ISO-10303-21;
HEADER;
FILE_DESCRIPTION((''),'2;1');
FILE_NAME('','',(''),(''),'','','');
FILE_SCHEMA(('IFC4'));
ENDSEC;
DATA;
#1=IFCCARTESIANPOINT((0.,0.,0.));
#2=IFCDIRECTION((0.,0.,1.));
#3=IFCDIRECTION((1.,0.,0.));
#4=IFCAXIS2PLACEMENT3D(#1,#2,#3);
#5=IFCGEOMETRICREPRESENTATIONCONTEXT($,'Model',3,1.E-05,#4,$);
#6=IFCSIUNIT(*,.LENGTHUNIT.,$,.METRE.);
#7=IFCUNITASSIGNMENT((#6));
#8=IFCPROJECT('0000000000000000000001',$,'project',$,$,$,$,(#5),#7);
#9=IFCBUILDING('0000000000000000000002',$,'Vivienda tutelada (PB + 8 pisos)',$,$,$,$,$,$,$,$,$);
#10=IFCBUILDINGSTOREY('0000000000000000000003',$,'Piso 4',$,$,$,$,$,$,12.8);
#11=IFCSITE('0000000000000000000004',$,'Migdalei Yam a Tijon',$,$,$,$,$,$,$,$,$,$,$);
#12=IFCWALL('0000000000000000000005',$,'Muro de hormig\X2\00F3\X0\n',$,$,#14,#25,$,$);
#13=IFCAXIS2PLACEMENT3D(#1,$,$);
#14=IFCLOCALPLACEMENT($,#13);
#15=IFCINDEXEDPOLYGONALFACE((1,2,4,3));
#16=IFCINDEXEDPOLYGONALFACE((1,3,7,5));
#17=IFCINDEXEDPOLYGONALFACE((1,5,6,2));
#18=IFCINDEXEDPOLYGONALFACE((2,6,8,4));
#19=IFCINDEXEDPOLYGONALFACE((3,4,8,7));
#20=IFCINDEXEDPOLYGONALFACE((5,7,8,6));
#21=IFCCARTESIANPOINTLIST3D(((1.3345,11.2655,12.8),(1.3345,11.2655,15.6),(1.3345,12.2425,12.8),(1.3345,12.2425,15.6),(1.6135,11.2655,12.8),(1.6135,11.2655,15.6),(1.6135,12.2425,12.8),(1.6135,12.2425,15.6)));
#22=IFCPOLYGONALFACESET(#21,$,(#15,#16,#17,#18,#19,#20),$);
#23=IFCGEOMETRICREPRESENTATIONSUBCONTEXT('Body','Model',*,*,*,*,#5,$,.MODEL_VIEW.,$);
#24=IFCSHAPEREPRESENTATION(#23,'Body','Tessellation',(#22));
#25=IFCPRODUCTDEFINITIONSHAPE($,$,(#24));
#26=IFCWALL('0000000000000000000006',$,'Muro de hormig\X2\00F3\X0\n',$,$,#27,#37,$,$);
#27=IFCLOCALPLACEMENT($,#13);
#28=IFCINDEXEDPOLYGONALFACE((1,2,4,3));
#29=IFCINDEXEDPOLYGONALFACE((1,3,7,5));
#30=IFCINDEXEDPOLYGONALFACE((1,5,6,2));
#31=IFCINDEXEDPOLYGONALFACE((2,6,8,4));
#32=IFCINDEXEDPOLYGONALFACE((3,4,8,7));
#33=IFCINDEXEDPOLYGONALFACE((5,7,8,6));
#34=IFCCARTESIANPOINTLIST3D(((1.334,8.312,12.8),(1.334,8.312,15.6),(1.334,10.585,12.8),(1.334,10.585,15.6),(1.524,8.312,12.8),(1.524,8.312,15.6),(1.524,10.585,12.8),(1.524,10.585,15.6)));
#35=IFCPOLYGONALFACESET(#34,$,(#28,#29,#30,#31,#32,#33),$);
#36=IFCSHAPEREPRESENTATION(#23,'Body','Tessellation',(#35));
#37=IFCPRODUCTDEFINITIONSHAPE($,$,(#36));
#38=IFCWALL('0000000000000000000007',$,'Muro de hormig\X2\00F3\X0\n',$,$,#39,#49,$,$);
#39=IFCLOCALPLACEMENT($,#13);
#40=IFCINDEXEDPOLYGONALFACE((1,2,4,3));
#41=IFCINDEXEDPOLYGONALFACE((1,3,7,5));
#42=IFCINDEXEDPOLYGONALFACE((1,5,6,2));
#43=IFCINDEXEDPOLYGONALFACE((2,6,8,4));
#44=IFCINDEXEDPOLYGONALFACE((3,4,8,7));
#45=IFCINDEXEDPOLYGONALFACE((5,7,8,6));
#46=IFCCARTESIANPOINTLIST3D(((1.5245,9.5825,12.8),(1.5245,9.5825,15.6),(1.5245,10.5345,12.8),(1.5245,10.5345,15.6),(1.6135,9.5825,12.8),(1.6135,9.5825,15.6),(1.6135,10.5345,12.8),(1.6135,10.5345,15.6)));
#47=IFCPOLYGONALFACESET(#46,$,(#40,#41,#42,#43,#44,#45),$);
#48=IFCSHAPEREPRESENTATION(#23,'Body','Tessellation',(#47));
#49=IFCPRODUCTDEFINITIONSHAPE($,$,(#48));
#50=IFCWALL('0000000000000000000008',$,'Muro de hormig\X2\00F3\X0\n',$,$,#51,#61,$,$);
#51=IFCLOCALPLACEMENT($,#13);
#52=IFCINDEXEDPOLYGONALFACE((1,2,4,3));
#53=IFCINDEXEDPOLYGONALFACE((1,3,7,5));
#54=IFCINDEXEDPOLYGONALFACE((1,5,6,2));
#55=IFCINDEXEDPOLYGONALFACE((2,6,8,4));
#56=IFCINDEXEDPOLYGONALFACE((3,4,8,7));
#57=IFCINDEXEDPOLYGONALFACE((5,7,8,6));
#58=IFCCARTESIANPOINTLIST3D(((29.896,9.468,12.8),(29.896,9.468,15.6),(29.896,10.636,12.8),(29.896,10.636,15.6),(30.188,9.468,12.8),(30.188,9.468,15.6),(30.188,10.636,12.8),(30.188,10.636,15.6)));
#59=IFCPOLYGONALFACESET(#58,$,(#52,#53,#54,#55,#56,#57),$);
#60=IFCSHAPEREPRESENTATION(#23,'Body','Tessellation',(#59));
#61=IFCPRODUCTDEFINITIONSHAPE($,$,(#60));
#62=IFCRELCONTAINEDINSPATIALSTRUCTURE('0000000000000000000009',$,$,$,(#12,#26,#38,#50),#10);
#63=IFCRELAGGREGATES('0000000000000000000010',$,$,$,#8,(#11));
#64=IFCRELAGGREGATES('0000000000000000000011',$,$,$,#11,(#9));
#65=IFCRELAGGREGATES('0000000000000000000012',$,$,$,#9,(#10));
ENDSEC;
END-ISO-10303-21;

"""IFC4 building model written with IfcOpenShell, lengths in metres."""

from ifc_helpers import new_model, si_unit, frame, origin_with_axes, context, subcontext, project, spatial, line, indexed_curve, outline, extrude, element, save


model = new_model("IFC4")

# Units and contexts
model_context = context("Model", 3, precision=1e-05, world=origin_with_axes())
body_context = subcontext(model_context, "Body", "Model", "MODEL_VIEW")
ifc_project = project(units=[si_unit("LENGTHUNIT", "METRE")], contexts=[model_context])

# Site, building, storey
site = spatial("IfcSite", under=ifc_project, Name="Migdalei Yam a Tijon")
building = spatial("IfcBuilding", under=site, Name="Vivienda tutelada (PB + 8 pisos)")
storey = spatial("IfcBuildingStorey", under=building, Name="Piso 4", Elevation=12.8)

# Walls
element("IfcWall", 1, inside=storey, Name="Muro de hormigón", context=body_context, shape_type="SweptSolid", body=[
    extrude(outline(indexed_curve([(0.0, 0.0), (0.279, 0.0), (0.279, 0.977), (0.0, 0.977)], segments=[line(1, 2, 3, 4, 1)])), frame((1.3345, 11.2655, 12.8), z_axis=(0.0, 0.0, 1.0), x_axis=(1.0, 0.0, 0.0)), (0.0, 0.0, 1.0), 2.8),
])
element("IfcWall", 2, inside=storey, Name="Muro de hormigón", context=body_context, shape_type="SweptSolid", body=[
    extrude(outline(indexed_curve([(0.0, 0.0), (0.19, 0.0), (0.19, 2.273), (0.0, 2.273)], segments=[line(1, 2, 3, 4, 1)])), frame((1.334, 8.312, 12.8), z_axis=(0.0, 0.0, 1.0), x_axis=(1.0, 0.0, 0.0)), (0.0, 0.0, 1.0), 2.8),
])
element("IfcWall", 3, inside=storey, Name="Muro de hormigón", context=body_context, shape_type="SweptSolid", body=[
    extrude(outline(indexed_curve([(0.0, 0.0), (0.089, 0.0), (0.089, 0.952), (0.0, 0.952)], segments=[line(1, 2, 3, 4, 1)])), frame((1.5245, 9.5825, 12.8), z_axis=(0.0, 0.0, 1.0), x_axis=(1.0, 0.0, 0.0)), (0.0, 0.0, 1.0), 2.8),
])
element("IfcWall", 4, inside=storey, Name="Muro de hormigón", context=body_context, shape_type="SweptSolid", body=[
    extrude(outline(indexed_curve([(0.0, 0.0), (0.292, 0.0), (0.292, 1.168), (0.0, 1.168)], segments=[line(1, 2, 3, 4, 1)])), frame((29.896, 9.468, 12.8), z_axis=(0.0, 0.0, 1.0), x_axis=(1.0, 0.0, 0.0)), (0.0, 0.0, 1.0), 2.8),
])

save(model, "model.ifc")
